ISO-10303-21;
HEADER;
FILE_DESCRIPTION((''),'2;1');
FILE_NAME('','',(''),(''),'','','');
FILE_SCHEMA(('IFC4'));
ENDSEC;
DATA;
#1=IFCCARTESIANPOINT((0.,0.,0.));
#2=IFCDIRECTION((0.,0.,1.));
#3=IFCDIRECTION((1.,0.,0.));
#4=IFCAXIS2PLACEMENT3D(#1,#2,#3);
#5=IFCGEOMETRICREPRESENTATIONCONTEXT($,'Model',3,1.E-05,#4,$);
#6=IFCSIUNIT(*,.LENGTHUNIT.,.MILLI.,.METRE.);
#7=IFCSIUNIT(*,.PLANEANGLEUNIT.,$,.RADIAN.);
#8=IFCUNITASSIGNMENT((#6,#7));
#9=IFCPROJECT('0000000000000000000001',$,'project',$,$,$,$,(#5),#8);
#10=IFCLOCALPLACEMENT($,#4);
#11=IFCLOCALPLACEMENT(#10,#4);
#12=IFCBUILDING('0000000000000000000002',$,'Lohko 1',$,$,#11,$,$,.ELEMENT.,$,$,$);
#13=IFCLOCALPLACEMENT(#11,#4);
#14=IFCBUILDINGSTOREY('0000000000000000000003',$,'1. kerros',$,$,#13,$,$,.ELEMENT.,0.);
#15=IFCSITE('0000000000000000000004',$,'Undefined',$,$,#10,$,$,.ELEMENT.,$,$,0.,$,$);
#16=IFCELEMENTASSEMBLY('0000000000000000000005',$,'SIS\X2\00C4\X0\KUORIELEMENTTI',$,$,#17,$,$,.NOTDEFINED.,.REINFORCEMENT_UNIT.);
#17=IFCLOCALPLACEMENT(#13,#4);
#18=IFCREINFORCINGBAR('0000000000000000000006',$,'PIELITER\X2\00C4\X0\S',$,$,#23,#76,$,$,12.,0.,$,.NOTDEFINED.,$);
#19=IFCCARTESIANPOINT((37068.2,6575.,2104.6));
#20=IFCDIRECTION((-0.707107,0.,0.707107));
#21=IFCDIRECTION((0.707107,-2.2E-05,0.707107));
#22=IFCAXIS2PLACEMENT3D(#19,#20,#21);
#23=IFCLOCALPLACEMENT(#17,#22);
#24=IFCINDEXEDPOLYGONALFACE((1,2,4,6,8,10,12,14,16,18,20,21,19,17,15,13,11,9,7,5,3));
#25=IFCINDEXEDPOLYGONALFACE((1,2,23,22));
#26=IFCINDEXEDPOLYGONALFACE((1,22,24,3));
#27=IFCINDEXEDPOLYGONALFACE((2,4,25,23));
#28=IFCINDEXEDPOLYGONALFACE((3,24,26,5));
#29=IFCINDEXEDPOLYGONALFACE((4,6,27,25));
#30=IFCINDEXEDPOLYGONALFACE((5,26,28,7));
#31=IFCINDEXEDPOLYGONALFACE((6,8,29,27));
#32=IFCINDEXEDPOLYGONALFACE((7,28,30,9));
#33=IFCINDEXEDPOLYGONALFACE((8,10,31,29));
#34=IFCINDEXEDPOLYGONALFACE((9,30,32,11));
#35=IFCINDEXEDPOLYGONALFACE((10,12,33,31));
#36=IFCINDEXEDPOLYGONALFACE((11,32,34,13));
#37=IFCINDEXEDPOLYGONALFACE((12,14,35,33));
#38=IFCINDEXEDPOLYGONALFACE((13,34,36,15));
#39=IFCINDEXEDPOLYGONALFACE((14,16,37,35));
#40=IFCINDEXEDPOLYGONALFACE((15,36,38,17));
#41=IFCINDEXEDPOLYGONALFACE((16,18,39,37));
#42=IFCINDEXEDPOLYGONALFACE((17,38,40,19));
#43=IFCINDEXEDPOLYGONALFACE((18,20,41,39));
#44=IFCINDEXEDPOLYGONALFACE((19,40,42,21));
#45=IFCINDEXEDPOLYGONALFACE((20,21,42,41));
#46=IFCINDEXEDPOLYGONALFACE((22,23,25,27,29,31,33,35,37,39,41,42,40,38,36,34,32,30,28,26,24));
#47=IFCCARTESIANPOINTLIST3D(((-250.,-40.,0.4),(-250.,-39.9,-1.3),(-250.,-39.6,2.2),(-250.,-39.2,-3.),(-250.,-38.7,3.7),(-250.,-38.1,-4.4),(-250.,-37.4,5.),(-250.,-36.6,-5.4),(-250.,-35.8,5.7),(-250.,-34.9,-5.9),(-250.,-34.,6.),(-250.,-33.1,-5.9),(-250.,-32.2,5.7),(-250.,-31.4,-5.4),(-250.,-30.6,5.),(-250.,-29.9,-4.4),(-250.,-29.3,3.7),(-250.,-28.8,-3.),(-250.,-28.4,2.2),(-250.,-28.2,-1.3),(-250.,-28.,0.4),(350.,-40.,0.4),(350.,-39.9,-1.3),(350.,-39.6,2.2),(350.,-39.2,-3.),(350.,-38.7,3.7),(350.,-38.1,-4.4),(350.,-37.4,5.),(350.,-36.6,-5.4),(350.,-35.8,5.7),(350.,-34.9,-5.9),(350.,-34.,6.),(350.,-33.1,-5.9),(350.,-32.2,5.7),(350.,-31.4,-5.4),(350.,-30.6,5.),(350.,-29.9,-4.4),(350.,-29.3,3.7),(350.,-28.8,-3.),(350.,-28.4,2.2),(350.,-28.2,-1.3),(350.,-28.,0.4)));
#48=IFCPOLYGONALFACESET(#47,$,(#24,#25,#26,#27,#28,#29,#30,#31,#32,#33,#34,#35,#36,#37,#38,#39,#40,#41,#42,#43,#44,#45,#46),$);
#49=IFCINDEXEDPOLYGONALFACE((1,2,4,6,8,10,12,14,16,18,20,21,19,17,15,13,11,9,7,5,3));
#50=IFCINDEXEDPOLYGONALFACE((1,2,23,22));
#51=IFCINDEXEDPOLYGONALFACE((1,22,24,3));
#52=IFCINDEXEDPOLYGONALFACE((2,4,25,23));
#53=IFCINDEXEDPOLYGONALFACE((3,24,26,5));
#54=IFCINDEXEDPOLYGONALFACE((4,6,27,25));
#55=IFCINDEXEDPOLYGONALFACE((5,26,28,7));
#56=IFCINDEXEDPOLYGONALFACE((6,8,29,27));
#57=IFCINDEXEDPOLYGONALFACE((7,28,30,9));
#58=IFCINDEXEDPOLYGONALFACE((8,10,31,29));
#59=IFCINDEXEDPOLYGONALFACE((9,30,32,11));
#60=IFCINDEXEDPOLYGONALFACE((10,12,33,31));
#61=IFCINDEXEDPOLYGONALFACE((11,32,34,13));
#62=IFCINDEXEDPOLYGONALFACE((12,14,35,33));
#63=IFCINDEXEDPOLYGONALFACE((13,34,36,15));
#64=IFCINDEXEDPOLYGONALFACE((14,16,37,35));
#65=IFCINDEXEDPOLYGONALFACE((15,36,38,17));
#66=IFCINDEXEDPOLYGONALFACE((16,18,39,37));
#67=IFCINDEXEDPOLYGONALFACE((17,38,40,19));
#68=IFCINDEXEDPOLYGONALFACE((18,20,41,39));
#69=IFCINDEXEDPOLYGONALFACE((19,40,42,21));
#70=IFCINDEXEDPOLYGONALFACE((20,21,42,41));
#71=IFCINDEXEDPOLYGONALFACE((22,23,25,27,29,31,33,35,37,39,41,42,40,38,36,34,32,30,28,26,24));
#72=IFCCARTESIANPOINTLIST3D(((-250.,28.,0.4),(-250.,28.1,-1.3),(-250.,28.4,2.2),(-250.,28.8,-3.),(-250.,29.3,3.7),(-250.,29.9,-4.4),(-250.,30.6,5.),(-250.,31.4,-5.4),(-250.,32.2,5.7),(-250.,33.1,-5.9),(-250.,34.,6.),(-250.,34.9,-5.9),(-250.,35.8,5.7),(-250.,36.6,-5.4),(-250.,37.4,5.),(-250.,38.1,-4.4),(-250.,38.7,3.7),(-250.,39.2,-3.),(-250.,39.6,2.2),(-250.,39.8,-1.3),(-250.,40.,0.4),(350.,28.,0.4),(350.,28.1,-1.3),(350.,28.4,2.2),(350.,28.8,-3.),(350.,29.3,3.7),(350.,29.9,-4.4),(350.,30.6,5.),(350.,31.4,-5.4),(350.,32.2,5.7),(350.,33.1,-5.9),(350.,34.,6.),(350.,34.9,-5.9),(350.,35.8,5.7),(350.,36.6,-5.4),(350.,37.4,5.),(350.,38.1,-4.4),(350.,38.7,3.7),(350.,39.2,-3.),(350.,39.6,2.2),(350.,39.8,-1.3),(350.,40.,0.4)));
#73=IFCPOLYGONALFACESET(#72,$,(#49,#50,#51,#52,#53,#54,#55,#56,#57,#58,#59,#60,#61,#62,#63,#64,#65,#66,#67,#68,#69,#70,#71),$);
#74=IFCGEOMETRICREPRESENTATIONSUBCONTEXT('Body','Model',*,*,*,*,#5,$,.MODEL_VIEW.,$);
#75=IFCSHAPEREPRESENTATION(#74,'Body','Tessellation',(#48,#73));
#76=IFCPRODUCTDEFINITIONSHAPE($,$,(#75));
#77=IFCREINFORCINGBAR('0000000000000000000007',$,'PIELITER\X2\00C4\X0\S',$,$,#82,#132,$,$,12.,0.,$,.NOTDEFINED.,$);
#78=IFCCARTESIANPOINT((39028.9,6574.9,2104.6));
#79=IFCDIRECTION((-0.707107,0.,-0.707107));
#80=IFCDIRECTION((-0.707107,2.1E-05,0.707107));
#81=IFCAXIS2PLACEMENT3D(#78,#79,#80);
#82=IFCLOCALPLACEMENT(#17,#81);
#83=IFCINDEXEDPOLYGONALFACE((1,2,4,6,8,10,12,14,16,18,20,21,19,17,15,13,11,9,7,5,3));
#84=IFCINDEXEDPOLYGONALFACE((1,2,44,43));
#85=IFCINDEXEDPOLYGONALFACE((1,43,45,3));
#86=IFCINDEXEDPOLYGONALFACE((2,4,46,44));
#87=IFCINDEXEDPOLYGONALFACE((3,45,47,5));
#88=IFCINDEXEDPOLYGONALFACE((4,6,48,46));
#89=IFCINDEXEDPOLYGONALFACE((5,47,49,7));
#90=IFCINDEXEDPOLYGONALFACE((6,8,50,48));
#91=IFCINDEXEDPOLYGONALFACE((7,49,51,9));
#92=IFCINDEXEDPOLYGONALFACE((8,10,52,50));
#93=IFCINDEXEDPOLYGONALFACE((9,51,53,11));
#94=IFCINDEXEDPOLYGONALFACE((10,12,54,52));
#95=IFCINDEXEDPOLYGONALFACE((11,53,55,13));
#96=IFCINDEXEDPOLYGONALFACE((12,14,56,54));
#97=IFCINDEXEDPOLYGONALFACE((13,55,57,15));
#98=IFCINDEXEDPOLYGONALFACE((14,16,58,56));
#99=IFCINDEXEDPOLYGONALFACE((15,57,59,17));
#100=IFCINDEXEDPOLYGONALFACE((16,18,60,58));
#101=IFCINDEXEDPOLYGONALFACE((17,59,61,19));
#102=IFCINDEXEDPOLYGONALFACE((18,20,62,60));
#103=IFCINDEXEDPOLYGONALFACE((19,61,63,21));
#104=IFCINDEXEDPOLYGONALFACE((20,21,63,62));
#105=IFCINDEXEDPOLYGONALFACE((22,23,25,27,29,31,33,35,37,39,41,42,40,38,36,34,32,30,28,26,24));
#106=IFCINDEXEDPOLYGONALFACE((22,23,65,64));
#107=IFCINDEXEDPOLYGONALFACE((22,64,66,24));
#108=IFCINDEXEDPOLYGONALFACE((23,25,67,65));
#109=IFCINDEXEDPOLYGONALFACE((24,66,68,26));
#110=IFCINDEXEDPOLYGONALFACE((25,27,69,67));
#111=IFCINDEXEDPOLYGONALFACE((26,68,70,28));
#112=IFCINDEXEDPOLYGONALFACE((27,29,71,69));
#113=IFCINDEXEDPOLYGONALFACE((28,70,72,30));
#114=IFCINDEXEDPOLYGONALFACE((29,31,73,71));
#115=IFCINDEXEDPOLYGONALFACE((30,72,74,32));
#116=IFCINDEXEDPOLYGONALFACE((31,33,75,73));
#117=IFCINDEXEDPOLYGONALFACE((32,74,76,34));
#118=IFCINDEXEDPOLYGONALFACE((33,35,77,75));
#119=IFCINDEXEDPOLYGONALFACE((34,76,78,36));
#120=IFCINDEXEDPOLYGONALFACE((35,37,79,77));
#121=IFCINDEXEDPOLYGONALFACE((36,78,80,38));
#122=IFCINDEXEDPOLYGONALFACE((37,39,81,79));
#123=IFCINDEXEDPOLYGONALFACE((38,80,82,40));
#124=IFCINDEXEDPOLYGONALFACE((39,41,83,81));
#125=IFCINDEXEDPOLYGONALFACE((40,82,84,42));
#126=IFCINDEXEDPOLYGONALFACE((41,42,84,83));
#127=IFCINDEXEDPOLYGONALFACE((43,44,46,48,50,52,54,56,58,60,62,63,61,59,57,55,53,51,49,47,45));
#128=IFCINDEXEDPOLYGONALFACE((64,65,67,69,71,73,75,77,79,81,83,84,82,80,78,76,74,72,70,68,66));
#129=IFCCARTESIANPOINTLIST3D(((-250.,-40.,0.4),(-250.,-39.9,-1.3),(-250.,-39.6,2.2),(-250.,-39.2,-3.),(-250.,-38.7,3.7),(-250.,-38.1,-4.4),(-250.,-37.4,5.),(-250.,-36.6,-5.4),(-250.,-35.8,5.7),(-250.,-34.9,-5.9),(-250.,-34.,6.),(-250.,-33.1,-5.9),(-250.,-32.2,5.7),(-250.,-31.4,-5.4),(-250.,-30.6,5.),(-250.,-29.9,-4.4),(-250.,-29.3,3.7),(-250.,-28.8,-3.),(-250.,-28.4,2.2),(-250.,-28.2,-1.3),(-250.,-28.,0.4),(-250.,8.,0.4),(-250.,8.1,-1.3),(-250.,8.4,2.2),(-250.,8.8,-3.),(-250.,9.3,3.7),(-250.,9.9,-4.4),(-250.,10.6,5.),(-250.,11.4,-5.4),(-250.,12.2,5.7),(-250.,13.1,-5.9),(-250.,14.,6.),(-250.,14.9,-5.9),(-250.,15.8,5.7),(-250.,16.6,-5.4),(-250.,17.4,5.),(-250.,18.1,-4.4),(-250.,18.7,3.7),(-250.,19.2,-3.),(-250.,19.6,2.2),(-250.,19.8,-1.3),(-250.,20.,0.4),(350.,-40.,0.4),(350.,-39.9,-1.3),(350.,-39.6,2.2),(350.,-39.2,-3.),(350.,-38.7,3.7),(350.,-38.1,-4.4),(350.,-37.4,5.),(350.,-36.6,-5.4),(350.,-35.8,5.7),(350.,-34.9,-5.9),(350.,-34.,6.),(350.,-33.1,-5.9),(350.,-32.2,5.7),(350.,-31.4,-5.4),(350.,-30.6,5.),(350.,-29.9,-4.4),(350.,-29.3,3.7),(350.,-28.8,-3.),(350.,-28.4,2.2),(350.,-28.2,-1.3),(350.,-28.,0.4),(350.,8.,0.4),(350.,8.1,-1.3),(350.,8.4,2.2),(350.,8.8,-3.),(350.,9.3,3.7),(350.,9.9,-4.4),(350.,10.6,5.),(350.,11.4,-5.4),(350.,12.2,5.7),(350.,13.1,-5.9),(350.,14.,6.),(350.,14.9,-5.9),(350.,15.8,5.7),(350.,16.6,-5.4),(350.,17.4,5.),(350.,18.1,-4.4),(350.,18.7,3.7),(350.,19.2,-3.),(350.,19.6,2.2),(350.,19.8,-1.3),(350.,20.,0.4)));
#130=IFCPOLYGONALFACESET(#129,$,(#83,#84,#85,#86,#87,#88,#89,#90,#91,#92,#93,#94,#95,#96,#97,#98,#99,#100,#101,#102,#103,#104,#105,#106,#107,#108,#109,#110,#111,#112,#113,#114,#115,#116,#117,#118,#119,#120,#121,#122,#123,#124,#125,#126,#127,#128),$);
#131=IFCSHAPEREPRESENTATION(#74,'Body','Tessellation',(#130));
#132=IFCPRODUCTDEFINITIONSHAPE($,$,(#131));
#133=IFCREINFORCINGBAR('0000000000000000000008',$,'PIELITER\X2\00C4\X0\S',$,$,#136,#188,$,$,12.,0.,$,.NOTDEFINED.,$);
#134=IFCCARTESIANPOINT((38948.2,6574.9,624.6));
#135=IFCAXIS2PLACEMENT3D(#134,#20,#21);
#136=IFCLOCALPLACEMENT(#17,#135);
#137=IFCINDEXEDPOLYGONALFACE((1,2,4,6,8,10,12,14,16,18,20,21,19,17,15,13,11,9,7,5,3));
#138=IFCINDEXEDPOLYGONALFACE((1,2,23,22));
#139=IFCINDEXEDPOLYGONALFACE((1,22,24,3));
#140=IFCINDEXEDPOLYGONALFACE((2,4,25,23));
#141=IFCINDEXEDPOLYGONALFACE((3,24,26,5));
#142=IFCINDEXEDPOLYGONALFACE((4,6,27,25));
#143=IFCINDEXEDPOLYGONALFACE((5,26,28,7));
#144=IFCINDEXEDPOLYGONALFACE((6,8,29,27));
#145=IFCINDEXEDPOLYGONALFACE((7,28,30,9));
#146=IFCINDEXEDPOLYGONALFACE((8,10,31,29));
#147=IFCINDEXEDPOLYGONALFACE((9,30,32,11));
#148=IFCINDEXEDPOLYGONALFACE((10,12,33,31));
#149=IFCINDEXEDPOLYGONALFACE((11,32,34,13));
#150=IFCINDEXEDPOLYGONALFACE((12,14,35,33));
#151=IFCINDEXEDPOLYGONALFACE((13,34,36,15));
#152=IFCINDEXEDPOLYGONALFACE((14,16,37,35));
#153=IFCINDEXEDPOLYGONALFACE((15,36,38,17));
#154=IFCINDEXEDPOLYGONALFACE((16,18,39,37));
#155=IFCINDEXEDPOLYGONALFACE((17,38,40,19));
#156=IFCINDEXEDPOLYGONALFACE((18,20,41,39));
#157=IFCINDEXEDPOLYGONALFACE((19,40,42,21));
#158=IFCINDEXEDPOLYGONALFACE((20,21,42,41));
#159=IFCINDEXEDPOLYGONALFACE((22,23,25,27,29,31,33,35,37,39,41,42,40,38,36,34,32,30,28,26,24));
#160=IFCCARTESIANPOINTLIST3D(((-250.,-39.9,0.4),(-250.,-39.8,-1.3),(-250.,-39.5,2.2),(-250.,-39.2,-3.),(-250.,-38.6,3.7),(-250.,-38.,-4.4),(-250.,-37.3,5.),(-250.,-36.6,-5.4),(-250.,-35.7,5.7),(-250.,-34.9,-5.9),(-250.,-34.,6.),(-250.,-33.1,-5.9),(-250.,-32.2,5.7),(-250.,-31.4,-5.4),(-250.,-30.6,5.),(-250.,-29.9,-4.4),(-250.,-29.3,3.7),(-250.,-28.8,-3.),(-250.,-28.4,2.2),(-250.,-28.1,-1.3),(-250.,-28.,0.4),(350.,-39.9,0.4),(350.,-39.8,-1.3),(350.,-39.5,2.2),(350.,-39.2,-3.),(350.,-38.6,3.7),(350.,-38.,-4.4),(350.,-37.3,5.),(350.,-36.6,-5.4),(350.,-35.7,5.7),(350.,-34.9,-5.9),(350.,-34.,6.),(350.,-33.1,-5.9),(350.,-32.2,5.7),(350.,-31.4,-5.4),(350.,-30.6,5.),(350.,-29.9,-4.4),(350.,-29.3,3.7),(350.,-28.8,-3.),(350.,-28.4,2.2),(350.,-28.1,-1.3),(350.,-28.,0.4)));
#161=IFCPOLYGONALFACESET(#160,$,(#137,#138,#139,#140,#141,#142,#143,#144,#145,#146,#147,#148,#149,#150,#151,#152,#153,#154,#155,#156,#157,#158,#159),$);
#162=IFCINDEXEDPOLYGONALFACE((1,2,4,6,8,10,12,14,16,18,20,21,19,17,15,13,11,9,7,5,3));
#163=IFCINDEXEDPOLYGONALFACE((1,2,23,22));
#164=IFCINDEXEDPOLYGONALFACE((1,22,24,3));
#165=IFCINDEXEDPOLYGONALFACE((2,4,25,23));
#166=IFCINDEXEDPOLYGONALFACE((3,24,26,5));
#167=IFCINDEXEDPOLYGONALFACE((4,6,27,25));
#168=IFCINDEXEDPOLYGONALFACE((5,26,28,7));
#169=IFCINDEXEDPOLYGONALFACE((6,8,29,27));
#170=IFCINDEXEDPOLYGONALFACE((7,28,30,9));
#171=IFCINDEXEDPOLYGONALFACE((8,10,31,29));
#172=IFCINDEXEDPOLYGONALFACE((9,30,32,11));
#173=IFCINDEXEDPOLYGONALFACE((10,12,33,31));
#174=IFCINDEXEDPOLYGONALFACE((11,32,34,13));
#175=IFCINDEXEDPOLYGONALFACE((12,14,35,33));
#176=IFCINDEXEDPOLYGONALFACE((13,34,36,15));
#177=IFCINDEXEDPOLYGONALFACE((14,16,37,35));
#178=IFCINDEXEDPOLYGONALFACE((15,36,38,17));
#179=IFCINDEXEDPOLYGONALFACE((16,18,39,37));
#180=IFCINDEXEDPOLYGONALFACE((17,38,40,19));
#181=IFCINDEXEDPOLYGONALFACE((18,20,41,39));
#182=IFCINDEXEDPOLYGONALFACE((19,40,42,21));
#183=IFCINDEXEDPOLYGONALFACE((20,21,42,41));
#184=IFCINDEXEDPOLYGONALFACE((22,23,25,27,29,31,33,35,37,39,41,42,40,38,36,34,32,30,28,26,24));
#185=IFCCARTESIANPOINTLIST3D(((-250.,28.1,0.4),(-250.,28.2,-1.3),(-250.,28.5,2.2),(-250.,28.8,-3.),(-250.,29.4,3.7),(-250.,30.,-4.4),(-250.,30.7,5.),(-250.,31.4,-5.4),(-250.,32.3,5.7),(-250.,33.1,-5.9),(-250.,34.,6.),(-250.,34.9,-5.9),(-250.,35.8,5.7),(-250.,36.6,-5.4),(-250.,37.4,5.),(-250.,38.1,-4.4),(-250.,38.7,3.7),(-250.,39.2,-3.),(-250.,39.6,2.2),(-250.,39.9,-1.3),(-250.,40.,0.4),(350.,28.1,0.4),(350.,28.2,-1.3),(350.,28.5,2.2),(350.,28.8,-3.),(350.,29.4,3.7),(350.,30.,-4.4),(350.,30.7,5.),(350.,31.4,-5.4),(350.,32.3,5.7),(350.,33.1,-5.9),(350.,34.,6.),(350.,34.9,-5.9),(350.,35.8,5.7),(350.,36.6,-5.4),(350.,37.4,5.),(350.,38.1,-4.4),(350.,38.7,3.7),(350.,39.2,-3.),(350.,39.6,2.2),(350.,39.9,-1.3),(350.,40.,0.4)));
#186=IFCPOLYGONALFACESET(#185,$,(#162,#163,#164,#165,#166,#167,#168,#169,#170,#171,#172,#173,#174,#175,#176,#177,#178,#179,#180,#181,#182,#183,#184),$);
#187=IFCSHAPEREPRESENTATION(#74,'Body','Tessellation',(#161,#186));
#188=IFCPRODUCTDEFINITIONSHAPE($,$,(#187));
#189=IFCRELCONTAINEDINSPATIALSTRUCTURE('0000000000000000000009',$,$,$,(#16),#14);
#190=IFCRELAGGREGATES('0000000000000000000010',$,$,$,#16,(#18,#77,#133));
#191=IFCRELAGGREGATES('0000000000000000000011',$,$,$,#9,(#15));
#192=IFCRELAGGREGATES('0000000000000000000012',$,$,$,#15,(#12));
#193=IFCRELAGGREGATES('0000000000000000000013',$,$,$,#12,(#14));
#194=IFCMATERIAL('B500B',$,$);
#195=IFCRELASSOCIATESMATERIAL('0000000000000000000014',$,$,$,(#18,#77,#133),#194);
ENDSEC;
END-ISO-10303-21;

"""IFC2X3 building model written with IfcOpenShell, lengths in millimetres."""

from ifc_helpers import new_model, entity, si_unit, frame, origin_with_axes, place, context, subcontext, project, spatial, source, transform, mapped, material, element, aggregate, save


model = new_model("IFC2X3")

# Units and contexts
model_context = context("Model", 3, precision=1e-05, world=origin_with_axes())
body_context = subcontext(model_context, "Body", "Model", "MODEL_VIEW")
ifc_project = project(units=[si_unit("LENGTHUNIT", "METRE", prefix="MILLI"), si_unit("PLANEANGLEUNIT", "RADIAN")], contexts=[model_context])

# Site, building, storey
site_placement = place(None, origin_with_axes())
site = spatial("IfcSite", under=ifc_project, at=site_placement, Name="Undefined", CompositionType="ELEMENT", RefElevation=0.0)
building_placement = place(site_placement, origin_with_axes())
building = spatial("IfcBuilding", under=site, at=building_placement, Name="Lohko 1", CompositionType="ELEMENT")
storey_placement = place(building_placement, origin_with_axes())
storey = spatial("IfcBuildingStorey", under=building, at=storey_placement, Name="1. kerros", CompositionType="ELEMENT", Elevation=0.0)

# Element assembly, reinforcing bars
assembly_placement = place(storey_placement, origin_with_axes())
assembly = element("IfcElementAssembly", 1, at=assembly_placement, inside=storey, Name="SISÄKUORIELEMENTTI", AssemblyPlace="NOTDEFINED", PredefinedType="REINFORCEMENT_UNIT")
ifc_material = material(Name="B500B")
shared_shape_1 = source(origin_with_axes(), body_context, "Body", "AdvancedSweptSolid", [
    entity("IfcSweptDiskSolid", entity("IfcTrimmedCurve", entity("IfcLine", entity("IfcCartesianPoint", [0.0, 0.0, 0.0]), entity("IfcVector", entity("IfcDirection", [1.0, 0.0, 0.0]), 1.0)), [entity("IfcParameterValue", 0.0)], [entity("IfcParameterValue", 600.0)], True, "PARAMETER"), 6.0, None, 0.0, 600.0),
])
shared_shape_2 = source(origin_with_axes(), body_context, "Body", "AdvancedSweptSolid", [
    entity("IfcSweptDiskSolid", entity("IfcTrimmedCurve", entity("IfcLine", entity("IfcCartesianPoint", [0.0, 0.0, 0.0]), entity("IfcVector", entity("IfcDirection", [1.0, 0.0, 0.0]), 1.0)), [entity("IfcParameterValue", 0.0)], [entity("IfcParameterValue", 600.0)], True, "PARAMETER"), 6.0, None, 0.0, 600.0),
])
reinforcing_bar_1_placement = place(assembly_placement, frame((37068.2, 6575.0, 2104.6), z_axis=(-0.707107, 0.0, 0.707107), x_axis=(0.707107, -0.000022, 0.707107)))
reinforcing_bar_1 = element("IfcReinforcingBar", 2, at=reinforcing_bar_1_placement, material=ifc_material, Name="PIELITERÄS", BarRole="NOTDEFINED", CrossSectionArea=0.0, NominalDiameter=12.0, context=body_context, shape_type="MappedRepresentation", body=[
    mapped(shared_shape_1, transform((-250.0, -34.0, 0.0))),
    mapped(shared_shape_2, transform((-250.0, 34.0, 0.0))),
])
shared_shape_3 = source(origin_with_axes(), body_context, "Body", "AdvancedSweptSolid", [
    entity("IfcSweptDiskSolid", entity("IfcTrimmedCurve", entity("IfcLine", entity("IfcCartesianPoint", [0.0, 0.0, 0.0]), entity("IfcVector", entity("IfcDirection", [1.0, 0.0, 0.0]), 1.0)), [entity("IfcParameterValue", 0.0)], [entity("IfcParameterValue", 600.0)], True, "PARAMETER"), 6.0, None, 0.0, 600.0),
])
shared_shape_4 = source(origin_with_axes(), body_context, "Body", "AdvancedSweptSolid", [
    entity("IfcSweptDiskSolid", entity("IfcTrimmedCurve", entity("IfcLine", entity("IfcCartesianPoint", [0.0, 0.0, 0.0]), entity("IfcVector", entity("IfcDirection", [1.0, 0.0, 0.0]), 1.0)), [entity("IfcParameterValue", 0.0)], [entity("IfcParameterValue", 600.0)], True, "PARAMETER"), 6.0, None, 0.0, 600.0),
])
reinforcing_bar_2_placement = place(assembly_placement, frame((39028.9, 6574.9, 2104.6), z_axis=(-0.707107, 0.0, -0.707107), x_axis=(-0.707107, 0.000021, 0.707107)))
reinforcing_bar_2 = element("IfcReinforcingBar", 3, at=reinforcing_bar_2_placement, material=ifc_material, Name="PIELITERÄS", BarRole="NOTDEFINED", CrossSectionArea=0.0, NominalDiameter=12.0, context=body_context, shape_type="MappedRepresentation", body=[
    mapped(shared_shape_3, transform((-250.0, -34.0, 0.0))),
    mapped(shared_shape_4, transform((-250.0, 14.0, 0.0))),
])
shared_shape_5 = source(origin_with_axes(), body_context, "Body", "AdvancedSweptSolid", [
    entity("IfcSweptDiskSolid", entity("IfcTrimmedCurve", entity("IfcLine", entity("IfcCartesianPoint", [0.0, 0.0, 0.0]), entity("IfcVector", entity("IfcDirection", [1.0, 0.0, 0.0]), 1.0)), [entity("IfcParameterValue", 0.0)], [entity("IfcParameterValue", 600.0)], True, "PARAMETER"), 6.0, None, 0.0, 600.0),
])
shared_shape_6 = source(origin_with_axes(), body_context, "Body", "AdvancedSweptSolid", [
    entity("IfcSweptDiskSolid", entity("IfcTrimmedCurve", entity("IfcLine", entity("IfcCartesianPoint", [0.0, 0.0, 0.0]), entity("IfcVector", entity("IfcDirection", [1.0, 0.0, 0.0]), 1.0)), [entity("IfcParameterValue", 0.0)], [entity("IfcParameterValue", 600.0)], True, "PARAMETER"), 6.0, None, 0.0, 600.0),
])
reinforcing_bar_3_placement = place(assembly_placement, frame((38948.2, 6574.9, 624.6), z_axis=(-0.707107, 0.0, 0.707107), x_axis=(0.707107, -0.000022, 0.707107)))
reinforcing_bar_3 = element("IfcReinforcingBar", 4, at=reinforcing_bar_3_placement, material=ifc_material, Name="PIELITERÄS", BarRole="NOTDEFINED", CrossSectionArea=0.0, NominalDiameter=12.0, context=body_context, shape_type="MappedRepresentation", body=[
    mapped(shared_shape_5, transform((-250.0, -34.0, 0.0))),
    mapped(shared_shape_6, transform((-250.0, 34.0, 0.0))),
])
aggregate(assembly, [reinforcing_bar_1, reinforcing_bar_2, reinforcing_bar_3])

save(model, "model.ifc")
